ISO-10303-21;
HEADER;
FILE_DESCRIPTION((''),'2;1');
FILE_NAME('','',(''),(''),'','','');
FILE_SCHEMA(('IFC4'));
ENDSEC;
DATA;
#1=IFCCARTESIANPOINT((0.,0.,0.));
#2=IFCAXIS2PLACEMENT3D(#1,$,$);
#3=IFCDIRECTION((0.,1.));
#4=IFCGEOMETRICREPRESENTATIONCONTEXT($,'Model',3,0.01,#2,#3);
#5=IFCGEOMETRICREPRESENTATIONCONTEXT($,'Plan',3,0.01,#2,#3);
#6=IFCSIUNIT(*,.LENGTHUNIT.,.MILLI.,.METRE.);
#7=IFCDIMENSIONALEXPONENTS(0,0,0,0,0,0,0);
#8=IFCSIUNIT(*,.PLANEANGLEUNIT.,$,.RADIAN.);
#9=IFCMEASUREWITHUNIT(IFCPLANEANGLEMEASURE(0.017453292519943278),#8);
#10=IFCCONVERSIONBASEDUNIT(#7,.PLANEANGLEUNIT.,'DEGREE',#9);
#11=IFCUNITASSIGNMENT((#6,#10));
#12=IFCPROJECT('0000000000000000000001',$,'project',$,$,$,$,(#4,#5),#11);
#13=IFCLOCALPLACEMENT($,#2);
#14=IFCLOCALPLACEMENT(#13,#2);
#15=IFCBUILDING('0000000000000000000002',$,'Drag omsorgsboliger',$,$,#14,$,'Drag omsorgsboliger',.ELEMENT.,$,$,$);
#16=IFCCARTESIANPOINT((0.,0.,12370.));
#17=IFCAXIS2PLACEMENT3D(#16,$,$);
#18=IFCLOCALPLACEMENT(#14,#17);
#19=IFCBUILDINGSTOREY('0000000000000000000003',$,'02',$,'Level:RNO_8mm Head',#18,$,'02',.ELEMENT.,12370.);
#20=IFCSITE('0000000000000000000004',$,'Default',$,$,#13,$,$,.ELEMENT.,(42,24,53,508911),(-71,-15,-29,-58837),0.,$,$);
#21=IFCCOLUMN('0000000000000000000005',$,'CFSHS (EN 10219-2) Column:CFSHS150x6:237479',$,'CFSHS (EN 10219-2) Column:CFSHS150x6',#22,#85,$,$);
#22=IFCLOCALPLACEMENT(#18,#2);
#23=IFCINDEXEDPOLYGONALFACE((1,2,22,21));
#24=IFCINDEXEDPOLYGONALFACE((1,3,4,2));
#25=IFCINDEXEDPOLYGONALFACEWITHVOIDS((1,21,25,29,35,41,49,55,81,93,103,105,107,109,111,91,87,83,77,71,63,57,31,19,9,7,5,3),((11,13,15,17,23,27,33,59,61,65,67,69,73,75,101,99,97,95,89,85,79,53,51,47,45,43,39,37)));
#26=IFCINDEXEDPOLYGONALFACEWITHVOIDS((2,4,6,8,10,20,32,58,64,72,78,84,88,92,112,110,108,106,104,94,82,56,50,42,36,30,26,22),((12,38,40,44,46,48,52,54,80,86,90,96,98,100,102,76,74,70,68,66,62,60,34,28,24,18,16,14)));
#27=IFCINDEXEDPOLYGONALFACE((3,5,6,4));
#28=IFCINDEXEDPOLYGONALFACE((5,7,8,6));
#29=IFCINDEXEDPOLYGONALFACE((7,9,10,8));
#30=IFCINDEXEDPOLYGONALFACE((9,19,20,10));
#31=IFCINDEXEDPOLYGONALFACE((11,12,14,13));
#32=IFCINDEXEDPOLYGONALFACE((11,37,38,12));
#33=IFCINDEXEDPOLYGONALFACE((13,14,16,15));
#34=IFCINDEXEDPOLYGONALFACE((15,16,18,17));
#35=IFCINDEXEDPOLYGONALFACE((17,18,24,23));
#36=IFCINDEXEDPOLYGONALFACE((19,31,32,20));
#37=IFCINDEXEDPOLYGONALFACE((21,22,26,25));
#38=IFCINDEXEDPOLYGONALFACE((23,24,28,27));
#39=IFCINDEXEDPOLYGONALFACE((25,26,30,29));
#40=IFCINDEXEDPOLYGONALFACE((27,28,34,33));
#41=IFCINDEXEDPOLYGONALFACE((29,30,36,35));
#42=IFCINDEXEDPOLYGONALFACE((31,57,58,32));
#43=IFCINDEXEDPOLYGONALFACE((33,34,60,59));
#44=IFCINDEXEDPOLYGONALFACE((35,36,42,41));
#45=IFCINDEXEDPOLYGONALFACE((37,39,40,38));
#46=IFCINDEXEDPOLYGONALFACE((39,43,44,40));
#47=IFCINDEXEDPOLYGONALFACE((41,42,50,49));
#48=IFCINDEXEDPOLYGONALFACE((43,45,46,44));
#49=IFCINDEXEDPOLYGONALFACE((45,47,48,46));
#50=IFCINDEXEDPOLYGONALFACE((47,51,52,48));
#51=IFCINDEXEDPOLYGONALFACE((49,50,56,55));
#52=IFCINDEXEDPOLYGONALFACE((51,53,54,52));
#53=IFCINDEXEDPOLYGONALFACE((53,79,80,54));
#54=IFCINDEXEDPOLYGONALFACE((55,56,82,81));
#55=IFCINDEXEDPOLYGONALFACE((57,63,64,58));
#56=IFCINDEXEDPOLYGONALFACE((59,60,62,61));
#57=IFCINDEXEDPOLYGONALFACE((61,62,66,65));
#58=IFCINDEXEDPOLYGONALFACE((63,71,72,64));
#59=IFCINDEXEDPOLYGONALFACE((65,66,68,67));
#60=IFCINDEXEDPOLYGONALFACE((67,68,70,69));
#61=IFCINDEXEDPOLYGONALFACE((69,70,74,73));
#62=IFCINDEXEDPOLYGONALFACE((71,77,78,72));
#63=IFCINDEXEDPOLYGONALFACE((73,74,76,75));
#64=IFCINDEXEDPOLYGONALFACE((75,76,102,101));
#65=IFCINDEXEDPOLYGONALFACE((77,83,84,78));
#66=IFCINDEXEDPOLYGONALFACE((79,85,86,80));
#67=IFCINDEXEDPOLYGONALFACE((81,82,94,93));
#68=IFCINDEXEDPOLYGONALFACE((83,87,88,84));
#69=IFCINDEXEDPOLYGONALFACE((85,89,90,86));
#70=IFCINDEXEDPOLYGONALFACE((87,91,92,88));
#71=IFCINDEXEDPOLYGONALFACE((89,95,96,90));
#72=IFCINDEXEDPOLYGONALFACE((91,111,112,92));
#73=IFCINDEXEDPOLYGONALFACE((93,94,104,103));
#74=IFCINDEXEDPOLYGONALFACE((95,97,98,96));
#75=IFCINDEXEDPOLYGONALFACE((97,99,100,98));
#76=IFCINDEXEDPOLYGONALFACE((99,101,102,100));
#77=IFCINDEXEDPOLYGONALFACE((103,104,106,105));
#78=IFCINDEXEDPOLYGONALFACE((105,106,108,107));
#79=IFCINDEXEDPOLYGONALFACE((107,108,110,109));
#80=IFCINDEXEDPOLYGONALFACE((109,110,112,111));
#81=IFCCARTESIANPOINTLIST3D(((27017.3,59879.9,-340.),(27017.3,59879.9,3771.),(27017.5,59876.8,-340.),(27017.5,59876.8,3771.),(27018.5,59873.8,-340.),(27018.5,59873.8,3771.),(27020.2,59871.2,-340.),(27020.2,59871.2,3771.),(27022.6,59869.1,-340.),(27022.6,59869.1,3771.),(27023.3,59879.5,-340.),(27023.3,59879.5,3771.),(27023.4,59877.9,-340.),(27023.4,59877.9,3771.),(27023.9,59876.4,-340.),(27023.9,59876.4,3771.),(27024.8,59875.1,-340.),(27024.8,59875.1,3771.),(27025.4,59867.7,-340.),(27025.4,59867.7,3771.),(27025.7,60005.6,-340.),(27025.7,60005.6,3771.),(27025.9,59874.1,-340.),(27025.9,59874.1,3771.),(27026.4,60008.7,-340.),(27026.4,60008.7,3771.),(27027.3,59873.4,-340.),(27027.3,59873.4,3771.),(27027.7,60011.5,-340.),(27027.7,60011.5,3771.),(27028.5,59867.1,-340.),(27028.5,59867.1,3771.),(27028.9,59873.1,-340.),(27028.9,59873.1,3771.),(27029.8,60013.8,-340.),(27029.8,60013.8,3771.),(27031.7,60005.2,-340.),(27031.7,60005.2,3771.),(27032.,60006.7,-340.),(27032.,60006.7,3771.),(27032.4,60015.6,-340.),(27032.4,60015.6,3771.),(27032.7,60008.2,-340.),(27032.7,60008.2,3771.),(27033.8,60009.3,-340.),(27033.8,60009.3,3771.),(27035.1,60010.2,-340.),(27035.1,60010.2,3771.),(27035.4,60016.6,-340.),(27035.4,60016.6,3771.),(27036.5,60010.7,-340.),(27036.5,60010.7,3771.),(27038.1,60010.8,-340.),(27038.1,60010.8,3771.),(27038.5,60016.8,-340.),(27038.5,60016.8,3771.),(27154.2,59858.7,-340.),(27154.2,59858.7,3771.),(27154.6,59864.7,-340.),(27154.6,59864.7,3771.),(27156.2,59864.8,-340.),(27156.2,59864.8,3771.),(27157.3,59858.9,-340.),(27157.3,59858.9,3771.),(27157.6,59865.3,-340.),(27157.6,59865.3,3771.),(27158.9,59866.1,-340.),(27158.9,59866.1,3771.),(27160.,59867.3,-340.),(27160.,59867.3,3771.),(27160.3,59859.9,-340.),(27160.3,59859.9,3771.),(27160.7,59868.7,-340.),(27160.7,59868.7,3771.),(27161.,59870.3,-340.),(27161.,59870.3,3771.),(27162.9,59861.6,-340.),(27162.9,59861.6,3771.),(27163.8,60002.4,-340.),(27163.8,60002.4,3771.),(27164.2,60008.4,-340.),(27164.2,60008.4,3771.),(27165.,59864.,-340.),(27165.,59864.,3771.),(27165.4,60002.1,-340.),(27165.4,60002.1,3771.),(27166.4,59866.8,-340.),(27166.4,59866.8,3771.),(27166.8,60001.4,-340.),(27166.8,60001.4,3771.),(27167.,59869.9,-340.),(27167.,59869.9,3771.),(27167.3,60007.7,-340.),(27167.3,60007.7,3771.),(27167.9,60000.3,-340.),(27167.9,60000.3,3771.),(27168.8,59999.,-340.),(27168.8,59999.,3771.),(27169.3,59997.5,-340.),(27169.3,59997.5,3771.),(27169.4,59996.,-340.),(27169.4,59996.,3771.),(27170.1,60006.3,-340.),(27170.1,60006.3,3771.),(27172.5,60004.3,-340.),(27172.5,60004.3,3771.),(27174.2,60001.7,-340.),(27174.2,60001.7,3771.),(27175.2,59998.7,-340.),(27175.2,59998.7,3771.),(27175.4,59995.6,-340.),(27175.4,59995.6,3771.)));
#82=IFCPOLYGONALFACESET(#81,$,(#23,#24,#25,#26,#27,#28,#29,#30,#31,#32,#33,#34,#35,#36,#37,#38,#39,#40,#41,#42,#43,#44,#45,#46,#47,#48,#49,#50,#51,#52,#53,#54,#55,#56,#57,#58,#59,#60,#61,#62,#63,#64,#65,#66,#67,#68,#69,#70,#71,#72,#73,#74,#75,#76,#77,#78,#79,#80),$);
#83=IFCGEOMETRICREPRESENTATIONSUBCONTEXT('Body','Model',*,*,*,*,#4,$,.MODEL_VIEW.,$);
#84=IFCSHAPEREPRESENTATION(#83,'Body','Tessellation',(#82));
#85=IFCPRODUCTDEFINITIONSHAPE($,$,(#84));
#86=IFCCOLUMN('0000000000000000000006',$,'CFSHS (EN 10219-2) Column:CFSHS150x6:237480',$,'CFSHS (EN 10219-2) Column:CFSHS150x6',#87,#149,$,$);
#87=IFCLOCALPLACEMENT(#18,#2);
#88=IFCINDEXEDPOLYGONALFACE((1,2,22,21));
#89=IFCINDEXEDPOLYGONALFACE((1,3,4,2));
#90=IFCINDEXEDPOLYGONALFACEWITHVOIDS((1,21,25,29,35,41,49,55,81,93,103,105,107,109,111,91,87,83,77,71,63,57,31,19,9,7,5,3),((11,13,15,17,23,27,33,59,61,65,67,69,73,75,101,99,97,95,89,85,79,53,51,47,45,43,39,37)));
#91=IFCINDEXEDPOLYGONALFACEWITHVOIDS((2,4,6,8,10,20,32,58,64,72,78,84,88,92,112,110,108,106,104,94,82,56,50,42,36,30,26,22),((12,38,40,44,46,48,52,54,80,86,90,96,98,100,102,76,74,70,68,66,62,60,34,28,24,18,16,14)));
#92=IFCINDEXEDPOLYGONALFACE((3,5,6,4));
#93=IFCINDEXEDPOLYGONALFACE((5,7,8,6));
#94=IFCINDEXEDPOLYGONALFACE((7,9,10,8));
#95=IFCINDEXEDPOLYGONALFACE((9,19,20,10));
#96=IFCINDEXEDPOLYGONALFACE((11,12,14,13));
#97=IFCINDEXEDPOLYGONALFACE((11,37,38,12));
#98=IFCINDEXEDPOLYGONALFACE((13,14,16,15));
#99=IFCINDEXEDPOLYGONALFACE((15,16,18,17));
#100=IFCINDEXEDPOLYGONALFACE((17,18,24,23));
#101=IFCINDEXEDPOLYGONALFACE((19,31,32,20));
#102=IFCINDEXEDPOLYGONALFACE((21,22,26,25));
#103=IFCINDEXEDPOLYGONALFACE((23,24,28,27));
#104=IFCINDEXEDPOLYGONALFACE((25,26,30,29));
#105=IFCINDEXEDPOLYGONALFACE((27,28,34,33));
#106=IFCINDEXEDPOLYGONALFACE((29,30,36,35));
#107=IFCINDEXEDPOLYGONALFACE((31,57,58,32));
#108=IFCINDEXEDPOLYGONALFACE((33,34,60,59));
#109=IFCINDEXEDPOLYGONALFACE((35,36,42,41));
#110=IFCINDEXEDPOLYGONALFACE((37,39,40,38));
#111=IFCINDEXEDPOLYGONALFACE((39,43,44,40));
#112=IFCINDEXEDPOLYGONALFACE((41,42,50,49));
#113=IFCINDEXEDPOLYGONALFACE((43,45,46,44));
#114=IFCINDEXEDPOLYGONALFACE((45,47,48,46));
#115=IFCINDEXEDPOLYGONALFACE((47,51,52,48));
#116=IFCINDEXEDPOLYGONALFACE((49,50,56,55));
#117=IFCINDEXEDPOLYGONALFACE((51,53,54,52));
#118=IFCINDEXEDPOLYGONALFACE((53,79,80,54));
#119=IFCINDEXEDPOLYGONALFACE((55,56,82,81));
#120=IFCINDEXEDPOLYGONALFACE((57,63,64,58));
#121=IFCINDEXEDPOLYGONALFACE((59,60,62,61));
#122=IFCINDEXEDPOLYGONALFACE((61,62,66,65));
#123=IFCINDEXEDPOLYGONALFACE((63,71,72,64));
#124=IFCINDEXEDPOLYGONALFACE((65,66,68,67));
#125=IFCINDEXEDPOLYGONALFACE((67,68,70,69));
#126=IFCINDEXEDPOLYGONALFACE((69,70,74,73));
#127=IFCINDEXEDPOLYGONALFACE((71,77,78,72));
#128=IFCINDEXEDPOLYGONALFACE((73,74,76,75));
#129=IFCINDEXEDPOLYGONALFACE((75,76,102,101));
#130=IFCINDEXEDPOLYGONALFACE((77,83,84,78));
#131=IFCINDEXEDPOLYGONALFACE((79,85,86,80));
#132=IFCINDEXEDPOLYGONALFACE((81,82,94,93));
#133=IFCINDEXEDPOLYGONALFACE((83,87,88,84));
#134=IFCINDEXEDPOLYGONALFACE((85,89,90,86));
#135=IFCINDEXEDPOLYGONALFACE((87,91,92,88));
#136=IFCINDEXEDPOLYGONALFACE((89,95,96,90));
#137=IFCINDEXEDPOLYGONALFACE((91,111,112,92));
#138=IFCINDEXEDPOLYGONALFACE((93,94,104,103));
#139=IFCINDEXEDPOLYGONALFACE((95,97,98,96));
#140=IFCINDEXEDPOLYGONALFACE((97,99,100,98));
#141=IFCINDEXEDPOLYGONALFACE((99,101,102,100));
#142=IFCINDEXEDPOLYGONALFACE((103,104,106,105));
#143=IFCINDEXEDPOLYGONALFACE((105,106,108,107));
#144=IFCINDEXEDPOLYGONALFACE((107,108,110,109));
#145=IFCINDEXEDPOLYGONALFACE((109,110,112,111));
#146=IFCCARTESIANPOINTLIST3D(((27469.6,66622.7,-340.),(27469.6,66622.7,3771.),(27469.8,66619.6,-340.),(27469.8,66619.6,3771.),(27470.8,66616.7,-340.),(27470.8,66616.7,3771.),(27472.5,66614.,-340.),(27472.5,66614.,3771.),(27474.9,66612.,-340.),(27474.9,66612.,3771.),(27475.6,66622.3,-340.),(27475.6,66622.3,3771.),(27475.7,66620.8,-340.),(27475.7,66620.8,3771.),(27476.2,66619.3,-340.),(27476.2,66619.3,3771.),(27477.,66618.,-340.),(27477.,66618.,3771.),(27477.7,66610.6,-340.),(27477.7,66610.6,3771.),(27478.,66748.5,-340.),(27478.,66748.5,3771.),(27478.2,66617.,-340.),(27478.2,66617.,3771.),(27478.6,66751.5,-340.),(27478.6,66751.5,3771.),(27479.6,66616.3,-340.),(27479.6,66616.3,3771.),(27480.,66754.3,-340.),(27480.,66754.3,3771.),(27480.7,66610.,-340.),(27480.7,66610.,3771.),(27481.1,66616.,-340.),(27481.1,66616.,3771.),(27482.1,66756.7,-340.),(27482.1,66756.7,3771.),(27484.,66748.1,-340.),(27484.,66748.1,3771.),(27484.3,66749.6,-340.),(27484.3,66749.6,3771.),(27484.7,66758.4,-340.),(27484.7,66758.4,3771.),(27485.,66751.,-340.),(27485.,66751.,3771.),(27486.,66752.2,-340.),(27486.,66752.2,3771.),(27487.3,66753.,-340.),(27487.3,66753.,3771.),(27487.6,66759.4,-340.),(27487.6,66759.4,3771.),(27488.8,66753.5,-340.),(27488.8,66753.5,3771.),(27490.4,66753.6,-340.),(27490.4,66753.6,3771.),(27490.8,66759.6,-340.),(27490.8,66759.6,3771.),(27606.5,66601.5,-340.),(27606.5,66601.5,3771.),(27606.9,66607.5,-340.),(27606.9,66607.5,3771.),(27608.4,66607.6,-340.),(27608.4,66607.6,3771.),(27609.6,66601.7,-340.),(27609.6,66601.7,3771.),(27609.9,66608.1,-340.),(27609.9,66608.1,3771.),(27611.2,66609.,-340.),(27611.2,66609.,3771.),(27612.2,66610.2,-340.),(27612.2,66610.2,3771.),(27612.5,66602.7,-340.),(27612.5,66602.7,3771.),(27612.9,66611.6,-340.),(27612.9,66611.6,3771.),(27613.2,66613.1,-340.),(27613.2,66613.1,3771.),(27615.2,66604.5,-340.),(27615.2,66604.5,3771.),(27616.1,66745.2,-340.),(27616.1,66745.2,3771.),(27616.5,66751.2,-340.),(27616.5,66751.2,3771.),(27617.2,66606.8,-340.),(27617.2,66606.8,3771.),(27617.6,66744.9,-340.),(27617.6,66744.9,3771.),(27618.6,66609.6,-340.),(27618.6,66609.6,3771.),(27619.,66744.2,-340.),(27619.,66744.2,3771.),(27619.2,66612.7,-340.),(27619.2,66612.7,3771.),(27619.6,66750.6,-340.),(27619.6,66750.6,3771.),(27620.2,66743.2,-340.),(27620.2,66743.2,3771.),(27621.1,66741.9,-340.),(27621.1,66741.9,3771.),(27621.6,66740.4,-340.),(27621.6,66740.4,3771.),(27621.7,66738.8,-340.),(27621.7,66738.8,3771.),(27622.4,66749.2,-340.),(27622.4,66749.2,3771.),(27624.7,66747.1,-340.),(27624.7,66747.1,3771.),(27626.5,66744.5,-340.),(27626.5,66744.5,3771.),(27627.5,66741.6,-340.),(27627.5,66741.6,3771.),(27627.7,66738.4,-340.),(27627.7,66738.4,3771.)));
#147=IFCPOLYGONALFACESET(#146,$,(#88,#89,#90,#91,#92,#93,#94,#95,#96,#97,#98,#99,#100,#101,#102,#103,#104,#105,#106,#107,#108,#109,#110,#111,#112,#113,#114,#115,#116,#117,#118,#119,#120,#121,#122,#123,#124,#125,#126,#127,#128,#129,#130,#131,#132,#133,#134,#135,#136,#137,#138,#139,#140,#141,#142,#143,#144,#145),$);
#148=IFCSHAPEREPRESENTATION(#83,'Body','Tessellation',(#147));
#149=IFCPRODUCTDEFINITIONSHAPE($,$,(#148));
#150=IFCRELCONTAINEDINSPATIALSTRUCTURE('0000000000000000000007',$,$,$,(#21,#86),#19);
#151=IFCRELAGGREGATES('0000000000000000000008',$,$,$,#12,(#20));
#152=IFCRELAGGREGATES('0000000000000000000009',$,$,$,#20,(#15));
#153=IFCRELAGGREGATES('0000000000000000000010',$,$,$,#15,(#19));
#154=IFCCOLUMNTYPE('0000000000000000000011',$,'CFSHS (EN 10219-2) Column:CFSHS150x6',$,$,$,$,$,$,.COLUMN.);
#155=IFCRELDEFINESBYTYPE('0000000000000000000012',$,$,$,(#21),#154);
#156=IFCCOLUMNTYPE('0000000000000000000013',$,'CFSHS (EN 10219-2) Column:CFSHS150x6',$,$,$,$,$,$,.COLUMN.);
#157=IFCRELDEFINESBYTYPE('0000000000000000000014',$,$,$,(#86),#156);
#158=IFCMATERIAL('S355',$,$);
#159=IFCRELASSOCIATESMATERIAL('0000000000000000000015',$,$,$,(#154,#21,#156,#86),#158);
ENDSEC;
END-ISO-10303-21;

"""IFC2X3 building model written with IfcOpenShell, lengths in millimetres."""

from ifc_helpers import new_model, entity, si_unit, converted_unit, direction, frame, frame_2d, origin, place, context, subcontext, project, spatial, polyline, circle_curve, parameter, trimmed, segment, composite_curve, outline, extrude, source, transform, mapped, material, type_object, type_shapes, element, save


model = new_model("IFC2X3")

# Units and contexts
model_context = context("Model", 3, precision=0.01, world=origin(), true_north=direction((0.0, 1.0)))
plan_context = context("Plan", 3, precision=0.01, world=origin(), true_north=direction((0.0, 1.0)))
body_context = subcontext(model_context, "Body", "Model", "MODEL_VIEW")
ifc_project = project(units=[si_unit("LENGTHUNIT", "METRE", prefix="MILLI"), converted_unit("PLANEANGLEUNIT", "DEGREE", entity("IfcPlaneAngleMeasure", 0.017453292519943278), si_unit("PLANEANGLEUNIT", "RADIAN"), dimensions=[0, 0, 0, 0, 0, 0, 0])], contexts=[model_context, plan_context])

# Site, building, storey
site_placement = place(None, origin())
site = spatial("IfcSite", under=ifc_project, at=site_placement, Name="Default", CompositionType="ELEMENT", RefLatitude=(42, 24, 53, 508911), RefLongitude=(-71, -15, -29, -58837), RefElevation=0.0)
building_placement = place(site_placement, origin())
building = spatial("IfcBuilding", under=site, at=building_placement, Name="Drag omsorgsboliger", LongName="Drag omsorgsboliger", CompositionType="ELEMENT")
storey_placement = place(building_placement, frame((0.0, 0.0, 12370.0)))
storey = spatial("IfcBuildingStorey", under=building, at=storey_placement, Name="02", ObjectType="Level:RNO_8mm Head", LongName="02", CompositionType="ELEMENT", Elevation=12370.0)

# Columns
ifc_material = material(Name="S355")
column_type_1 = type_object("IfcColumnType", Name="CFSHS (EN 10219-2) Column:CFSHS150x6", PredefinedType="COLUMN", material=ifc_material)
shared_shape_1 = source(origin(), body_context, "Body", "SweptSolid", [
    extrude(outline(composite_curve([segment(polyline([(-63.0, -75.0), (63.0, -75.0)]), True, "CONTINUOUS"), segment(trimmed(circle_curve(frame_2d((63.0, -63.0), x_axis=(-1.0, 0.0)), 12.0), [parameter(90.0)], [parameter(180.0)], True, "PARAMETER"), True, "CONTINUOUS"), segment(polyline([(75.0, -63.0), (75.0, 63.0)]), True, "CONTINUOUS"), segment(trimmed(circle_curve(frame_2d((63.0, 63.0), x_axis=(-1.0, 0.0)), 12.0), [parameter(180.0)], [parameter(270.0)], True, "PARAMETER"), True, "CONTINUOUS"), segment(polyline([(63.0, 75.0), (-63.0, 75.0)]), True, "CONTINUOUS"), segment(trimmed(circle_curve(frame_2d((-63.0, 63.0), x_axis=(-1.0, 0.0)), 12.0), [parameter(270.0)], [parameter(360.0)], True, "PARAMETER"), True, "CONTINUOUS"), segment(polyline([(-75.0, 63.0), (-75.0, -63.0)]), True, "CONTINUOUS"), segment(trimmed(circle_curve(frame_2d((-63.0, -63.0), x_axis=(-1.0, 0.0)), 12.0), [parameter(360.0)], [parameter(90.0)], True, "PARAMETER"), True, "CONTINUOUS")], self_intersect=False), holes=[composite_curve([segment(trimmed(circle_curve(frame_2d((-63.0, -63.0), x_axis=(-1.0, 0.0)), 6.0), [parameter(360.0)], [parameter(90.0)], True, "PARAMETER"), False, "CONTINUOUS"), segment(polyline([(-69.0, -63.0), (-69.0, 63.0)]), True, "CONTINUOUS"), segment(trimmed(circle_curve(frame_2d((-63.0, 63.0), x_axis=(-1.0, 0.0)), 6.0), [parameter(270.0)], [parameter(360.0)], True, "PARAMETER"), False, "CONTINUOUS"), segment(polyline([(-63.0, 69.0), (63.0, 69.0)]), True, "CONTINUOUS"), segment(trimmed(circle_curve(frame_2d((63.0, 63.0), x_axis=(-1.0, 0.0)), 6.0), [parameter(180.0)], [parameter(270.0)], True, "PARAMETER"), False, "CONTINUOUS"), segment(polyline([(69.0, 63.0), (69.0, -63.0)]), True, "CONTINUOUS"), segment(trimmed(circle_curve(frame_2d((63.0, -63.0), x_axis=(-1.0, 0.0)), 6.0), [parameter(90.0)], [parameter(180.0)], True, "PARAMETER"), False, "CONTINUOUS"), segment(polyline([(63.0, -69.0), (-63.0, -69.0)]), True, "CONTINUOUS")], self_intersect=False)]), frame((27096.4, 59937.7, 12030.0), z_axis=(0.0, 0.0, 1.0), x_axis=(-0.997758, 0.066923, 0.0)), (0.0, 0.0, 1.0), 4111.0),
])
type_shapes(column_type_1, [shared_shape_1])
column_1_placement = place(storey_placement, frame((0.0, 0.0, -12370.0)))
element("IfcColumn", 1, at=column_1_placement, inside=storey, type_object=column_type_1, material=ifc_material, Name="CFSHS (EN 10219-2) Column:CFSHS150x6:237479", ObjectType="CFSHS (EN 10219-2) Column:CFSHS150x6", context=body_context, shape_type="MappedRepresentation", body=[
    mapped(shared_shape_1, transform((0.0, 0.0, 0.0), scale=1.0)),
])
column_type_2 = type_object("IfcColumnType", Name="CFSHS (EN 10219-2) Column:CFSHS150x6", PredefinedType="COLUMN", material=ifc_material)
shared_shape_2 = source(origin(), body_context, "Body", "SweptSolid", [
    extrude(outline(composite_curve([segment(polyline([(-63.0, -75.0), (63.0, -75.0)]), True, "CONTINUOUS"), segment(trimmed(circle_curve(frame_2d((63.0, -63.0), x_axis=(-1.0, 0.0)), 12.0), [parameter(90.0)], [parameter(180.0)], True, "PARAMETER"), True, "CONTINUOUS"), segment(polyline([(75.0, -63.0), (75.0, 63.0)]), True, "CONTINUOUS"), segment(trimmed(circle_curve(frame_2d((63.0, 63.0), x_axis=(-1.0, 0.0)), 12.0), [parameter(180.0)], [parameter(270.0)], True, "PARAMETER"), True, "CONTINUOUS"), segment(polyline([(63.0, 75.0), (-63.0, 75.0)]), True, "CONTINUOUS"), segment(trimmed(circle_curve(frame_2d((-63.0, 63.0), x_axis=(-1.0, 0.0)), 12.0), [parameter(270.0)], [parameter(360.0)], True, "PARAMETER"), True, "CONTINUOUS"), segment(polyline([(-75.0, 63.0), (-75.0, -63.0)]), True, "CONTINUOUS"), segment(trimmed(circle_curve(frame_2d((-63.0, -63.0), x_axis=(-1.0, 0.0)), 12.0), [parameter(360.0)], [parameter(90.0)], True, "PARAMETER"), True, "CONTINUOUS")], self_intersect=False), holes=[composite_curve([segment(trimmed(circle_curve(frame_2d((-63.0, -63.0), x_axis=(-1.0, 0.0)), 6.0), [parameter(360.0)], [parameter(90.0)], True, "PARAMETER"), False, "CONTINUOUS"), segment(polyline([(-69.0, -63.0), (-69.0, 63.0)]), True, "CONTINUOUS"), segment(trimmed(circle_curve(frame_2d((-63.0, 63.0), x_axis=(-1.0, 0.0)), 6.0), [parameter(270.0)], [parameter(360.0)], True, "PARAMETER"), False, "CONTINUOUS"), segment(polyline([(-63.0, 69.0), (63.0, 69.0)]), True, "CONTINUOUS"), segment(trimmed(circle_curve(frame_2d((63.0, 63.0), x_axis=(-1.0, 0.0)), 6.0), [parameter(180.0)], [parameter(270.0)], True, "PARAMETER"), False, "CONTINUOUS"), segment(polyline([(69.0, 63.0), (69.0, -63.0)]), True, "CONTINUOUS"), segment(trimmed(circle_curve(frame_2d((63.0, -63.0), x_axis=(-1.0, 0.0)), 6.0), [parameter(90.0)], [parameter(180.0)], True, "PARAMETER"), False, "CONTINUOUS"), segment(polyline([(63.0, -69.0), (-63.0, -69.0)]), True, "CONTINUOUS")], self_intersect=False)]), frame((27548.6, 66680.6, 12030.0), z_axis=(0.0, 0.0, 1.0), x_axis=(-0.997758, 0.066923, 0.0)), (0.0, 0.0, 1.0), 4111.0),
])
type_shapes(column_type_2, [shared_shape_2])
column_2_placement = place(storey_placement, frame((0.0, 0.0, -12370.0)))
element("IfcColumn", 2, at=column_2_placement, inside=storey, type_object=column_type_2, material=ifc_material, Name="CFSHS (EN 10219-2) Column:CFSHS150x6:237480", ObjectType="CFSHS (EN 10219-2) Column:CFSHS150x6", context=body_context, shape_type="MappedRepresentation", body=[
    mapped(shared_shape_2, transform((0.0, 0.0, 0.0), scale=1.0)),
])

save(model, "model.ifc")
